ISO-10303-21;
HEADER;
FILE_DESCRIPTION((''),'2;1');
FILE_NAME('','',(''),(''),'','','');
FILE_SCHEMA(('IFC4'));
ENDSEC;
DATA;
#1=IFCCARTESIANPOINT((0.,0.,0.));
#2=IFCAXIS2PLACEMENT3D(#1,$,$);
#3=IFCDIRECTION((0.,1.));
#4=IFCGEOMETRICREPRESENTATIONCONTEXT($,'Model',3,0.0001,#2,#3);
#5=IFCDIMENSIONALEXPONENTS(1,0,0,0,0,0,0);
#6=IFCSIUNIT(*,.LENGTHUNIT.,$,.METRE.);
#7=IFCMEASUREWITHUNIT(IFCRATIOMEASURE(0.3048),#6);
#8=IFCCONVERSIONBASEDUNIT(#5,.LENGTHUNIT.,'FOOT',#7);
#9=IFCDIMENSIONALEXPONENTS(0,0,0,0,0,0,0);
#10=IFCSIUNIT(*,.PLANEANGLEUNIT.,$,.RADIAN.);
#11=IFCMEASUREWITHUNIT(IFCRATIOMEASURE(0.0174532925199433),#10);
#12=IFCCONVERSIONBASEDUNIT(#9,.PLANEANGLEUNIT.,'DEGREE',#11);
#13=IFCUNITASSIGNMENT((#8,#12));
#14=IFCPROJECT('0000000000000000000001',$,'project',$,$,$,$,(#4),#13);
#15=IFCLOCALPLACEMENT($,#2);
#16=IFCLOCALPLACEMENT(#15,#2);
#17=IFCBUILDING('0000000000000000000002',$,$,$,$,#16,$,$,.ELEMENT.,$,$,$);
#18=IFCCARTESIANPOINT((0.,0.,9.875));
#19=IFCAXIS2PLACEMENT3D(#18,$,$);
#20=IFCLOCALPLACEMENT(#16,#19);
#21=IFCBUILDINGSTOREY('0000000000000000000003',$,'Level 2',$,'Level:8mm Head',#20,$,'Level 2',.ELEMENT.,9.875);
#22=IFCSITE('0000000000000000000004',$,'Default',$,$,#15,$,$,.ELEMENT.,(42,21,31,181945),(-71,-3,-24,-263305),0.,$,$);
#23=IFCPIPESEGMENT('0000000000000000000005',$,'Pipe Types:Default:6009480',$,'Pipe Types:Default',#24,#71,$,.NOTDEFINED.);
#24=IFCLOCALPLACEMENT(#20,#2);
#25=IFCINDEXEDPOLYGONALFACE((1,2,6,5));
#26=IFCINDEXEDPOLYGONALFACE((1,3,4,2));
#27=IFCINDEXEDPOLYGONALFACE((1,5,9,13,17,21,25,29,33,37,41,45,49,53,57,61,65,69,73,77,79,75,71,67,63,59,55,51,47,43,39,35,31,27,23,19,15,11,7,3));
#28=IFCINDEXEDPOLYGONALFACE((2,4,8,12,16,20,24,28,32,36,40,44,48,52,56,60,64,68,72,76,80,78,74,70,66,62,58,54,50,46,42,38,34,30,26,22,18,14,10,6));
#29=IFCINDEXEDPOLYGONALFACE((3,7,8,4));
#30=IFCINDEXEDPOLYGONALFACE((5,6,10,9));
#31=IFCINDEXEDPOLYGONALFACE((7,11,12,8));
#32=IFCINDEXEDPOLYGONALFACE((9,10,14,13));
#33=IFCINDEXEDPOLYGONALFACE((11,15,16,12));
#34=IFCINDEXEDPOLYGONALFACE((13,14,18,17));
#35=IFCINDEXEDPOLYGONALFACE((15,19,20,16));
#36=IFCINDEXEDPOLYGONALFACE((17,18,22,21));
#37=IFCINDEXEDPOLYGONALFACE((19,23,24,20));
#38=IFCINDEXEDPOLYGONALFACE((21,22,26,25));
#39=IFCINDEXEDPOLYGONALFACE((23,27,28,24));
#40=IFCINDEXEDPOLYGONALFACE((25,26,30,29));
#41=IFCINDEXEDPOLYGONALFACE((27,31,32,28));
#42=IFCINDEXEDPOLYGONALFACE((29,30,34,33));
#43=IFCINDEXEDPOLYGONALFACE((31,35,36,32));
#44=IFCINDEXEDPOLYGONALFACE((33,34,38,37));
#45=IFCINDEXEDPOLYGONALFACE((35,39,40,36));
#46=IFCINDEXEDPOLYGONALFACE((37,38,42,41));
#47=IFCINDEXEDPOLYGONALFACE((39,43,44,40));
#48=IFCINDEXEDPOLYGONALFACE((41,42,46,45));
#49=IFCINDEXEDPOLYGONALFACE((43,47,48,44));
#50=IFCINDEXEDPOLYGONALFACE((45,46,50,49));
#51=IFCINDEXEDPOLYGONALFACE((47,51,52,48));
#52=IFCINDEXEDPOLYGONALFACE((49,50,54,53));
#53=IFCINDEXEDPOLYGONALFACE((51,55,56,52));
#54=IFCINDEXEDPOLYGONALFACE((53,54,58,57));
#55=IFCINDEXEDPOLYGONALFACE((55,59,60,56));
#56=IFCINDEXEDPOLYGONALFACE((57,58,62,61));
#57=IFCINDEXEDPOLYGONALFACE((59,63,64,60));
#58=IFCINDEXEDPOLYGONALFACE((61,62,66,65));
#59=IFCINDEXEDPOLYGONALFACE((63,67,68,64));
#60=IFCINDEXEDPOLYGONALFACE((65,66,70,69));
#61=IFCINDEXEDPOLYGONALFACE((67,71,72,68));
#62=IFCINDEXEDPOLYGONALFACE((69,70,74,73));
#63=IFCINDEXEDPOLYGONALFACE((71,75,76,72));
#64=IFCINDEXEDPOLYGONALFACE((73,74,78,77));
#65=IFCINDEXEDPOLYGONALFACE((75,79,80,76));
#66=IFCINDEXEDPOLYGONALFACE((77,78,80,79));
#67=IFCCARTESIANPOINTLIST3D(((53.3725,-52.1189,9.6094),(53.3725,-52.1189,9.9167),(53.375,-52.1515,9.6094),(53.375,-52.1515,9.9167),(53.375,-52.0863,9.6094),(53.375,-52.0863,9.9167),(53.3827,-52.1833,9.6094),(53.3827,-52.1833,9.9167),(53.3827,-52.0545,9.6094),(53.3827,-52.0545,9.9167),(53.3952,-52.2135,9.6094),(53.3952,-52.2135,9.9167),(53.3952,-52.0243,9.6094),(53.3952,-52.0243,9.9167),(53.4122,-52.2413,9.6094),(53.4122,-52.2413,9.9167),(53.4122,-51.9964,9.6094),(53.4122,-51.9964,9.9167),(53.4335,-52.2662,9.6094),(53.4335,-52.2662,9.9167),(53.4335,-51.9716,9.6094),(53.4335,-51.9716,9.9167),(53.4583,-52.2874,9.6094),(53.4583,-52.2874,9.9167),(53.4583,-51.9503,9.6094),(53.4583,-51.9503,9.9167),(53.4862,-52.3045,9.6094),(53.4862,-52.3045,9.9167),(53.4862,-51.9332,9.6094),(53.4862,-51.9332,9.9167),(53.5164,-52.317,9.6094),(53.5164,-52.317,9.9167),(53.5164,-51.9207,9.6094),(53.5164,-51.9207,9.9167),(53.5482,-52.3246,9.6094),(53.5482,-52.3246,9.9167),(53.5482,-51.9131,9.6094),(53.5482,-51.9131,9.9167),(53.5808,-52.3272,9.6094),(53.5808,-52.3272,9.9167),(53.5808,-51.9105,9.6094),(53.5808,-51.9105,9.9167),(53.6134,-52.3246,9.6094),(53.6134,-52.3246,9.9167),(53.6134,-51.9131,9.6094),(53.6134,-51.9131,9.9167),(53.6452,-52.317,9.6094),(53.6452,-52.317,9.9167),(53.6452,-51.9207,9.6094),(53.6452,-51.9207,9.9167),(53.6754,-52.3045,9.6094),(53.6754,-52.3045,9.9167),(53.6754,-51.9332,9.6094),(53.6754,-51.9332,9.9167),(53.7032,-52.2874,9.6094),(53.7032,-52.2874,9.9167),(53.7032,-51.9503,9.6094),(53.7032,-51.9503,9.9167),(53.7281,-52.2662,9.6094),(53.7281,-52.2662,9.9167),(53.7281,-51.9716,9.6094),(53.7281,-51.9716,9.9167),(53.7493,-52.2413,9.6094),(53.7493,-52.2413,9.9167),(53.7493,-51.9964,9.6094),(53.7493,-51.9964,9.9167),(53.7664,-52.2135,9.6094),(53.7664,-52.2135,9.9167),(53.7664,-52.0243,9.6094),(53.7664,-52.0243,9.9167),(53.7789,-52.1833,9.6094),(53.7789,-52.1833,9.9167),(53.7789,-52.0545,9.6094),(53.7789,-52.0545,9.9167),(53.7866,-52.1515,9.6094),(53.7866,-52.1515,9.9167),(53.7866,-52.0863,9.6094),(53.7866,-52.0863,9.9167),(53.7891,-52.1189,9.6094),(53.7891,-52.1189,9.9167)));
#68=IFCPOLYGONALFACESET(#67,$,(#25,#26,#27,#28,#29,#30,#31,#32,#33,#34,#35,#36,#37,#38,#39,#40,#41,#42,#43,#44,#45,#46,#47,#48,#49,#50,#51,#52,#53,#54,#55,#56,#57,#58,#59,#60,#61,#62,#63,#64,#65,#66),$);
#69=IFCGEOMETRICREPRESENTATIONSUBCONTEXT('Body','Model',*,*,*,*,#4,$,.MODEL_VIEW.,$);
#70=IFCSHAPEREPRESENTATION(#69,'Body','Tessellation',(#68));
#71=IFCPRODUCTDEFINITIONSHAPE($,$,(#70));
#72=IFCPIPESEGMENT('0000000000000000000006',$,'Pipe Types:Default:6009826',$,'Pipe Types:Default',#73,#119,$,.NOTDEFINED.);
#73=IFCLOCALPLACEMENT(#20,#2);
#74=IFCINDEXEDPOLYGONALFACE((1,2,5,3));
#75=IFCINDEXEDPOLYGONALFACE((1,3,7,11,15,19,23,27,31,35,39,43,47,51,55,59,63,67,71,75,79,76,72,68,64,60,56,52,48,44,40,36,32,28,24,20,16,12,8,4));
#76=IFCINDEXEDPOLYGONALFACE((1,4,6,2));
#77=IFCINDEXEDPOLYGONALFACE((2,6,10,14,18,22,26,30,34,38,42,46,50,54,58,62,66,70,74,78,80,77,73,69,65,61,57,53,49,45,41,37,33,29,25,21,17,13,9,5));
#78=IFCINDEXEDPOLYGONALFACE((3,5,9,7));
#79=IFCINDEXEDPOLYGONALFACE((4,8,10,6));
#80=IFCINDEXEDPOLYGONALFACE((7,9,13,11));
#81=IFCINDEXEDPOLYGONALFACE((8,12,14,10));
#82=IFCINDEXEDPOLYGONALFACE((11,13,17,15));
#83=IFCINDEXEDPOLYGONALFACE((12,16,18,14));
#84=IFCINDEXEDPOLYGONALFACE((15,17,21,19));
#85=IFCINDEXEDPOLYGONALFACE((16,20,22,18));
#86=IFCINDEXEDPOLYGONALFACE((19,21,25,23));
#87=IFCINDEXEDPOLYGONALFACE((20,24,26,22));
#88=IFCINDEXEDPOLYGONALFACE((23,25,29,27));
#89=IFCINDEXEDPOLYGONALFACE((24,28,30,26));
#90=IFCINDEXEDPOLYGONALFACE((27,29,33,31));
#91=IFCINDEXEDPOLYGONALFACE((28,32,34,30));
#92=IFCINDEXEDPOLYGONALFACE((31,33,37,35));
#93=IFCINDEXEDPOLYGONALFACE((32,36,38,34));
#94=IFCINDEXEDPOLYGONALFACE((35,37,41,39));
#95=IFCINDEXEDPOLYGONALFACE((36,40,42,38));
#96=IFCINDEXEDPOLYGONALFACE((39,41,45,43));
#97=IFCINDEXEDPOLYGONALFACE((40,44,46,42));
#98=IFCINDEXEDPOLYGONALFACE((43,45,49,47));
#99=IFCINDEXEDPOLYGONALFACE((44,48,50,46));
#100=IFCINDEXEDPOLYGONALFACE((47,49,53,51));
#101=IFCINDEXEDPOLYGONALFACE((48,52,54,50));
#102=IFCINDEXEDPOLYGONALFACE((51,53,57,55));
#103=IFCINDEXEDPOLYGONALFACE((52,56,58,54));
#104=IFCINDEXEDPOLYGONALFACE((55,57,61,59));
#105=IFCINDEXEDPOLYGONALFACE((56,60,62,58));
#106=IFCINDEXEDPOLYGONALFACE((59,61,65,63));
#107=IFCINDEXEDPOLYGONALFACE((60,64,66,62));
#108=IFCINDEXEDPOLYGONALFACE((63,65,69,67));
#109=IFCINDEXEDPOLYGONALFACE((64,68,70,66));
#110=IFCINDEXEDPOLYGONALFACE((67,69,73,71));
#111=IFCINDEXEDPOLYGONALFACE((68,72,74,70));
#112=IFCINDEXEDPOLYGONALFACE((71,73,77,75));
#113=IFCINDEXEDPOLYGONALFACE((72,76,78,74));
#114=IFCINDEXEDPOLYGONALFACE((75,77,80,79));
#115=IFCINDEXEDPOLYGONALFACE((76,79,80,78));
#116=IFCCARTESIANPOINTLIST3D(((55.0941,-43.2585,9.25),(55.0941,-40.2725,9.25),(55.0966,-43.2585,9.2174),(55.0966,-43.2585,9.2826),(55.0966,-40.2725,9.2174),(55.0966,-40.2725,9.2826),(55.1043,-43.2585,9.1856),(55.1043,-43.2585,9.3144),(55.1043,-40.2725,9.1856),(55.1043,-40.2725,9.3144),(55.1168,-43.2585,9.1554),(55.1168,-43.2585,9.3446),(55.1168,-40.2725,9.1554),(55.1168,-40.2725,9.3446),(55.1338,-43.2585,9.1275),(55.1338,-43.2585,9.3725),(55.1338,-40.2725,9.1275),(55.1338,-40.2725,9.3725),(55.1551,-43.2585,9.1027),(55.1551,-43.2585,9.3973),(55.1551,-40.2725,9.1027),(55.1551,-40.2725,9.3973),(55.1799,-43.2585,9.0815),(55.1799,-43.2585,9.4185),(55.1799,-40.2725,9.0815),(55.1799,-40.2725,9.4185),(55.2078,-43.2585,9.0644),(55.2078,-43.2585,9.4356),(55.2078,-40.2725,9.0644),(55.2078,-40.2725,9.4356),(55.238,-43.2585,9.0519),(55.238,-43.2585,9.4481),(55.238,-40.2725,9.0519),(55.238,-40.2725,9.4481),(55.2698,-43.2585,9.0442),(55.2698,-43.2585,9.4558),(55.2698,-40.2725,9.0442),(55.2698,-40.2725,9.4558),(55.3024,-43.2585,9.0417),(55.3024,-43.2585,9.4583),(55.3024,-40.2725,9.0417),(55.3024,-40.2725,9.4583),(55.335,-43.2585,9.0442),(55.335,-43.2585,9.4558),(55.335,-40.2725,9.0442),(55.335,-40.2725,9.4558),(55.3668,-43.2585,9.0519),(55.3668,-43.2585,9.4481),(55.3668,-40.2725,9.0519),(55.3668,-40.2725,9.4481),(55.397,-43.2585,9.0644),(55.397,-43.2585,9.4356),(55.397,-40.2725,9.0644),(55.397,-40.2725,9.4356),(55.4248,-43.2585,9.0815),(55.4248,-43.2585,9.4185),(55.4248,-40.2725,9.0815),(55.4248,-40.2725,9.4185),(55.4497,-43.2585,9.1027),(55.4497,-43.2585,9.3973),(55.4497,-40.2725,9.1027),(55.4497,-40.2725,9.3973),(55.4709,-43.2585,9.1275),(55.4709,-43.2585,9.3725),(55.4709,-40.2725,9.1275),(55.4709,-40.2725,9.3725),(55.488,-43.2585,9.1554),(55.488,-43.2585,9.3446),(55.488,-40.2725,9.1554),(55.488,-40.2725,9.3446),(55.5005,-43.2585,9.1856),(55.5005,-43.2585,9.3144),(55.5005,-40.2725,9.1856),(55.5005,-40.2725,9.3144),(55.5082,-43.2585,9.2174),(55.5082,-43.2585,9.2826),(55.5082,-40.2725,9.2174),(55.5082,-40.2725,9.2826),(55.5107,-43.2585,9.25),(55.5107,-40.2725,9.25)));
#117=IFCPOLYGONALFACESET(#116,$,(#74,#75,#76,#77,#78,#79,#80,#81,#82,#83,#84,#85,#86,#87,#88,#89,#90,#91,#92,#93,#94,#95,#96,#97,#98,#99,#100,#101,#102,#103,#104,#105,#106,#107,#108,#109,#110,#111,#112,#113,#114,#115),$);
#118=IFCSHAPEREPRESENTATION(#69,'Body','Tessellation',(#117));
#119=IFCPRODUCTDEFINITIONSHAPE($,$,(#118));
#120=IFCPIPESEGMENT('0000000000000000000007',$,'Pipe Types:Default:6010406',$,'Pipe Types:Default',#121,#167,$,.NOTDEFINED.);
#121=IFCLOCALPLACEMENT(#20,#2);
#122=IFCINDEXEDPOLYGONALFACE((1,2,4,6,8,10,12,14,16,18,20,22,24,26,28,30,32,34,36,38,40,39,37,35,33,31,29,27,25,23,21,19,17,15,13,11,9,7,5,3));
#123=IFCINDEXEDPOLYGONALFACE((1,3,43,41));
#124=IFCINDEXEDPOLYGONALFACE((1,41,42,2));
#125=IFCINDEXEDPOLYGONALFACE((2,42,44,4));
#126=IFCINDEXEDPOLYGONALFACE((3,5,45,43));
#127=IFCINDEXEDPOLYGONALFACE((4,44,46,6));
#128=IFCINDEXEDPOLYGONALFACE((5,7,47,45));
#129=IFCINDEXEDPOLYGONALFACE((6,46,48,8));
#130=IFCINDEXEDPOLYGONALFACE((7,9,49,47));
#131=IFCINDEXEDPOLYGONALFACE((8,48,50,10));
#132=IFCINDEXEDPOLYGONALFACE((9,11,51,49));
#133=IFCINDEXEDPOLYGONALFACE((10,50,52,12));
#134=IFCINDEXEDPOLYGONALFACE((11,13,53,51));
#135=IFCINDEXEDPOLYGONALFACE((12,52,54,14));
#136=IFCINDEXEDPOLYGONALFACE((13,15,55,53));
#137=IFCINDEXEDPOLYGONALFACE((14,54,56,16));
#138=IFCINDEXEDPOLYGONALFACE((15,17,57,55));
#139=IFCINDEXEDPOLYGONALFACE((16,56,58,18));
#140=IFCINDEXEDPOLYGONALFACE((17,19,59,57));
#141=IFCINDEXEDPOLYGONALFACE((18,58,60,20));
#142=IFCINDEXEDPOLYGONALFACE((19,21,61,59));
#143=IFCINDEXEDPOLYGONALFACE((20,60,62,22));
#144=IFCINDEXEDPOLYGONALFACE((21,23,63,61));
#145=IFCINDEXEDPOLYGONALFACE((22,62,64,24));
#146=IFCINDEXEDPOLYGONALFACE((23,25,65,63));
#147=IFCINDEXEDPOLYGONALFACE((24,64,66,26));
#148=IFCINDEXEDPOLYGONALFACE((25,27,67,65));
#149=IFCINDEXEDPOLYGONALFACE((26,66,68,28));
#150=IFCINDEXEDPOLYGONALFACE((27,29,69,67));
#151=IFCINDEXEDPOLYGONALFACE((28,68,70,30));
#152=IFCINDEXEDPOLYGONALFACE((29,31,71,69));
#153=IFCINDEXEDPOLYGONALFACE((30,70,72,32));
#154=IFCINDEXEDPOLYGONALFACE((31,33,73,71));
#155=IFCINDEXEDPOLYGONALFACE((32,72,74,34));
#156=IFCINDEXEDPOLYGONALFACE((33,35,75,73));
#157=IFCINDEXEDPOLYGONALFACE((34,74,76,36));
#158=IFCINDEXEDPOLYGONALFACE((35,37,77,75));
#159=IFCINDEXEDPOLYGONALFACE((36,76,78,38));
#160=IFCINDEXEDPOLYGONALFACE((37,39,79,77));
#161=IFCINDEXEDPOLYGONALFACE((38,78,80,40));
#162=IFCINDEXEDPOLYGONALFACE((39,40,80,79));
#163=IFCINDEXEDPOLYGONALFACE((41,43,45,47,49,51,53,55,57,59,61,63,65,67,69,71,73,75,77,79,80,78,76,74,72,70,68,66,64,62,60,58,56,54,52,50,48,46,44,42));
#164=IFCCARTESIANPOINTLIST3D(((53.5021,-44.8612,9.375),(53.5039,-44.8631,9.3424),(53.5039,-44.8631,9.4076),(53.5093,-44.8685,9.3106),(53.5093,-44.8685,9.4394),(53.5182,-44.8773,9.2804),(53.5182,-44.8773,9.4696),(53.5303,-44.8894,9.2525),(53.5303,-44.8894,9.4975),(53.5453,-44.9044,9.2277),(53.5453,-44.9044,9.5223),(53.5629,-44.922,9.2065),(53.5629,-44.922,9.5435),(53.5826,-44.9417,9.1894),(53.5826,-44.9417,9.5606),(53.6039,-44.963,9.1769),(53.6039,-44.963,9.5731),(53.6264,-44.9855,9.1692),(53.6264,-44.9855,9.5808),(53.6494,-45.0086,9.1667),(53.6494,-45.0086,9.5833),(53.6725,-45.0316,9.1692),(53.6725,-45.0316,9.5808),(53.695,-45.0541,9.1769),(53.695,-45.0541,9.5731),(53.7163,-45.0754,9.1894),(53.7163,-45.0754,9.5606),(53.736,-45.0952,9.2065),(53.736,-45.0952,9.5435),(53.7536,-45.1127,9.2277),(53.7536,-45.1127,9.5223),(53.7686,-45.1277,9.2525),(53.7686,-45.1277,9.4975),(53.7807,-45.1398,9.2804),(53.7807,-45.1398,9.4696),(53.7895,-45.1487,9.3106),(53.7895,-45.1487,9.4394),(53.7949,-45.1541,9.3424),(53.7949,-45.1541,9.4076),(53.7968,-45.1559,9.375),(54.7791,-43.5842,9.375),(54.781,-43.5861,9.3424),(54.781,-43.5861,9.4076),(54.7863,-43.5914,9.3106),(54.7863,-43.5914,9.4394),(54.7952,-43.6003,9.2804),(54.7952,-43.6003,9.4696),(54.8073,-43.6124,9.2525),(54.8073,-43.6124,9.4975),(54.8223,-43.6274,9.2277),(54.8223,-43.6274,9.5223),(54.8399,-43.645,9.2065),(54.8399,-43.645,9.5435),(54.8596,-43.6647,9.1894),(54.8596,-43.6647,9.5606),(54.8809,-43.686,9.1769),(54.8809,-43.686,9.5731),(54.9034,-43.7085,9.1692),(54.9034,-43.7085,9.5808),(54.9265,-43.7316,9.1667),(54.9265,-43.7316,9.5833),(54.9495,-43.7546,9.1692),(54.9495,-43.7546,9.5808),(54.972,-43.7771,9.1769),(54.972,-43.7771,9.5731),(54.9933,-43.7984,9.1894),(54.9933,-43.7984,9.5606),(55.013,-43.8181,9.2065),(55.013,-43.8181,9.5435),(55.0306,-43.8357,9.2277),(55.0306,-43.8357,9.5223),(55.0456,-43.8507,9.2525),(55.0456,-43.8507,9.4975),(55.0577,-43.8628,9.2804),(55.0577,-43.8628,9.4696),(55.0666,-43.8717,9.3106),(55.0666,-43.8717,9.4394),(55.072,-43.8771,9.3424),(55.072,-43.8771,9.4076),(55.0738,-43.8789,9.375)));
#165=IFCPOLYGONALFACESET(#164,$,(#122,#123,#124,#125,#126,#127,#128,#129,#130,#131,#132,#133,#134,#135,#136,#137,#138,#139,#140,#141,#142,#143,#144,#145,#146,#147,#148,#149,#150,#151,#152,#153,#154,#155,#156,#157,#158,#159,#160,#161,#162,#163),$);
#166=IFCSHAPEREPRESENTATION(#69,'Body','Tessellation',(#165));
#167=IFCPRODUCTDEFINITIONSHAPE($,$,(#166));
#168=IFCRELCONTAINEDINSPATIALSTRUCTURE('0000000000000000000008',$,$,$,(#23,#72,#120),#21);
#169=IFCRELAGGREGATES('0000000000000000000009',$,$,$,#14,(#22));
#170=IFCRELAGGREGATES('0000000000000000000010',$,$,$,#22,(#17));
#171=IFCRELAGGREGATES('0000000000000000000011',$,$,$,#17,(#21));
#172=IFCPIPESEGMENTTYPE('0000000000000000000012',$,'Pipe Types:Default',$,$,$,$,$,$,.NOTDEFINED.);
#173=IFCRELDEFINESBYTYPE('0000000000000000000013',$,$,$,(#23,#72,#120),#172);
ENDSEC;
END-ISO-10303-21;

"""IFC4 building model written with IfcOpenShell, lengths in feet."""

from ifc_helpers import new_model, entity, si_unit, converted_unit, direction, frame, origin, place, context, subcontext, project, spatial, indexed_curve, outline, extrude, type_object, element, save


model = new_model("IFC4")

# Units and contexts
model_context = context("Model", 3, precision=0.0001, world=origin(), true_north=direction((0.0, 1.0)))
body_context = subcontext(model_context, "Body", "Model", "MODEL_VIEW")
ifc_project = project(units=[converted_unit("LENGTHUNIT", "FOOT", entity("IfcRatioMeasure", 0.3048), si_unit("LENGTHUNIT", "METRE"), dimensions=[1, 0, 0, 0, 0, 0, 0]), converted_unit("PLANEANGLEUNIT", "DEGREE", entity("IfcRatioMeasure", 0.0174532925199433), si_unit("PLANEANGLEUNIT", "RADIAN"), dimensions=[0, 0, 0, 0, 0, 0, 0])], contexts=[model_context])

# Site, building, storey
site_placement = place(None, origin())
site = spatial("IfcSite", under=ifc_project, at=site_placement, Name="Default", CompositionType="ELEMENT", RefLatitude=(42, 21, 31, 181945), RefLongitude=(-71, -3, -24, -263305), RefElevation=0.0)
building_placement = place(site_placement, origin())
building = spatial("IfcBuilding", under=site, at=building_placement, CompositionType="ELEMENT")
storey_placement = place(building_placement, frame((0.0, 0.0, 9.875)))
storey = spatial("IfcBuildingStorey", under=building, at=storey_placement, Name="Level 2", ObjectType="Level:8mm Head", LongName="Level 2", CompositionType="ELEMENT", Elevation=9.875)

# Pipe segments
pipe_segment_type = type_object("IfcPipeSegmentType", Name="Pipe Types:Default", PredefinedType="NOTDEFINED")
pipe_segment_1_placement = place(storey_placement, origin())
element("IfcPipeSegment", 1, at=pipe_segment_1_placement, inside=storey, type_object=pipe_segment_type, Name="Pipe Types:Default:6009480", ObjectType="Pipe Types:Default", PredefinedType="NOTDEFINED", context=body_context, shape_type="SweptSolid", body=[
    extrude(outline(indexed_curve([(0.2083, 0.0), (0.2058, 0.0326), (0.1981, 0.0644), (0.1856, 0.0946), (0.1685, 0.1225), (0.1473, 0.1473), (0.1225, 0.1685), (0.0946, 0.1856), (0.0644, 0.1981), (0.0326, 0.2058), (0.0, 0.2083), (-0.0326, 0.2058), (-0.0644, 0.1981), (-0.0946, 0.1856), (-0.1225, 0.1685), (-0.1473, 0.1473), (-0.1685, 0.1225), (-0.1856, 0.0946), (-0.1981, 0.0644), (-0.2058, 0.0326), (-0.2083, 0.0), (-0.2058, -0.0326), (-0.1981, -0.0644), (-0.1856, -0.0946), (-0.1685, -0.1225), (-0.1473, -0.1473), (-0.1225, -0.1685), (-0.0946, -0.1856), (-0.0644, -0.1981), (-0.0326, -0.2058), (0.0, -0.2083), (0.0326, -0.2058), (0.0644, -0.1981), (0.0946, -0.1856), (0.1225, -0.1685), (0.1473, -0.1473), (0.1685, -0.1225), (0.1856, -0.0946), (0.1981, -0.0644), (0.2058, -0.0326), (0.2083, 0.0)], self_intersect=False)), frame((53.5808, -52.1189, 9.6094), z_axis=(0.0, 0.0, 1.0), x_axis=(-1.0, 0.0, 0.0)), (0.0, 0.0, 1.0), 0.3073),
])
pipe_segment_2_placement = place(storey_placement, origin())
element("IfcPipeSegment", 2, at=pipe_segment_2_placement, inside=storey, type_object=pipe_segment_type, Name="Pipe Types:Default:6009826", ObjectType="Pipe Types:Default", PredefinedType="NOTDEFINED", context=body_context, shape_type="SweptSolid", body=[
    extrude(outline(indexed_curve([(0.2083, 0.0), (0.2058, 0.0326), (0.1981, 0.0644), (0.1856, 0.0946), (0.1685, 0.1225), (0.1473, 0.1473), (0.1225, 0.1685), (0.0946, 0.1856), (0.0644, 0.1981), (0.0326, 0.2058), (0.0, 0.2083), (-0.0326, 0.2058), (-0.0644, 0.1981), (-0.0946, 0.1856), (-0.1225, 0.1685), (-0.1473, 0.1473), (-0.1685, 0.1225), (-0.1856, 0.0946), (-0.1981, 0.0644), (-0.2058, 0.0326), (-0.2083, 0.0), (-0.2058, -0.0326), (-0.1981, -0.0644), (-0.1856, -0.0946), (-0.1685, -0.1225), (-0.1473, -0.1473), (-0.1225, -0.1685), (-0.0946, -0.1856), (-0.0644, -0.1981), (-0.0326, -0.2058), (0.0, -0.2083), (0.0326, -0.2058), (0.0644, -0.1981), (0.0946, -0.1856), (0.1225, -0.1685), (0.1473, -0.1473), (0.1685, -0.1225), (0.1856, -0.0946), (0.1981, -0.0644), (0.2058, -0.0326), (0.2083, 0.0)], self_intersect=False)), frame((55.3024, -43.2585, 9.25), z_axis=(0.0, 1.0, 0.0), x_axis=(1.0, 0.0, 0.0)), (0.0, 0.0, 1.0), 2.986),
])
pipe_segment_3_placement = place(storey_placement, origin())
element("IfcPipeSegment", 3, at=pipe_segment_3_placement, inside=storey, type_object=pipe_segment_type, Name="Pipe Types:Default:6010406", ObjectType="Pipe Types:Default", PredefinedType="NOTDEFINED", context=body_context, shape_type="SweptSolid", body=[
    extrude(outline(indexed_curve([(0.2083, 0.0), (0.2058, 0.0326), (0.1981, 0.0644), (0.1856, 0.0946), (0.1685, 0.1225), (0.1473, 0.1473), (0.1225, 0.1685), (0.0946, 0.1856), (0.0644, 0.1981), (0.0326, 0.2058), (0.0, 0.2083), (-0.0326, 0.2058), (-0.0644, 0.1981), (-0.0946, 0.1856), (-0.1225, 0.1685), (-0.1473, 0.1473), (-0.1685, 0.1225), (-0.1856, 0.0946), (-0.1981, 0.0644), (-0.2058, 0.0326), (-0.2083, 0.0), (-0.2058, -0.0326), (-0.1981, -0.0644), (-0.1856, -0.0946), (-0.1685, -0.1225), (-0.1473, -0.1473), (-0.1225, -0.1685), (-0.0946, -0.1856), (-0.0644, -0.1981), (-0.0326, -0.2058), (0.0, -0.2083), (0.0326, -0.2058), (0.0644, -0.1981), (0.0946, -0.1856), (0.1225, -0.1685), (0.1473, -0.1473), (0.1685, -0.1225), (0.1856, -0.0946), (0.1981, -0.0644), (0.2058, -0.0326), (0.2083, 0.0)], self_intersect=False)), frame((53.6494, -45.0086, 9.375), z_axis=(0.707107, 0.707107, 0.0), x_axis=(-0.707107, 0.707107, 0.0)), (0.0, 0.0, 1.0), 1.806),
])

save(model, "model.ifc")
